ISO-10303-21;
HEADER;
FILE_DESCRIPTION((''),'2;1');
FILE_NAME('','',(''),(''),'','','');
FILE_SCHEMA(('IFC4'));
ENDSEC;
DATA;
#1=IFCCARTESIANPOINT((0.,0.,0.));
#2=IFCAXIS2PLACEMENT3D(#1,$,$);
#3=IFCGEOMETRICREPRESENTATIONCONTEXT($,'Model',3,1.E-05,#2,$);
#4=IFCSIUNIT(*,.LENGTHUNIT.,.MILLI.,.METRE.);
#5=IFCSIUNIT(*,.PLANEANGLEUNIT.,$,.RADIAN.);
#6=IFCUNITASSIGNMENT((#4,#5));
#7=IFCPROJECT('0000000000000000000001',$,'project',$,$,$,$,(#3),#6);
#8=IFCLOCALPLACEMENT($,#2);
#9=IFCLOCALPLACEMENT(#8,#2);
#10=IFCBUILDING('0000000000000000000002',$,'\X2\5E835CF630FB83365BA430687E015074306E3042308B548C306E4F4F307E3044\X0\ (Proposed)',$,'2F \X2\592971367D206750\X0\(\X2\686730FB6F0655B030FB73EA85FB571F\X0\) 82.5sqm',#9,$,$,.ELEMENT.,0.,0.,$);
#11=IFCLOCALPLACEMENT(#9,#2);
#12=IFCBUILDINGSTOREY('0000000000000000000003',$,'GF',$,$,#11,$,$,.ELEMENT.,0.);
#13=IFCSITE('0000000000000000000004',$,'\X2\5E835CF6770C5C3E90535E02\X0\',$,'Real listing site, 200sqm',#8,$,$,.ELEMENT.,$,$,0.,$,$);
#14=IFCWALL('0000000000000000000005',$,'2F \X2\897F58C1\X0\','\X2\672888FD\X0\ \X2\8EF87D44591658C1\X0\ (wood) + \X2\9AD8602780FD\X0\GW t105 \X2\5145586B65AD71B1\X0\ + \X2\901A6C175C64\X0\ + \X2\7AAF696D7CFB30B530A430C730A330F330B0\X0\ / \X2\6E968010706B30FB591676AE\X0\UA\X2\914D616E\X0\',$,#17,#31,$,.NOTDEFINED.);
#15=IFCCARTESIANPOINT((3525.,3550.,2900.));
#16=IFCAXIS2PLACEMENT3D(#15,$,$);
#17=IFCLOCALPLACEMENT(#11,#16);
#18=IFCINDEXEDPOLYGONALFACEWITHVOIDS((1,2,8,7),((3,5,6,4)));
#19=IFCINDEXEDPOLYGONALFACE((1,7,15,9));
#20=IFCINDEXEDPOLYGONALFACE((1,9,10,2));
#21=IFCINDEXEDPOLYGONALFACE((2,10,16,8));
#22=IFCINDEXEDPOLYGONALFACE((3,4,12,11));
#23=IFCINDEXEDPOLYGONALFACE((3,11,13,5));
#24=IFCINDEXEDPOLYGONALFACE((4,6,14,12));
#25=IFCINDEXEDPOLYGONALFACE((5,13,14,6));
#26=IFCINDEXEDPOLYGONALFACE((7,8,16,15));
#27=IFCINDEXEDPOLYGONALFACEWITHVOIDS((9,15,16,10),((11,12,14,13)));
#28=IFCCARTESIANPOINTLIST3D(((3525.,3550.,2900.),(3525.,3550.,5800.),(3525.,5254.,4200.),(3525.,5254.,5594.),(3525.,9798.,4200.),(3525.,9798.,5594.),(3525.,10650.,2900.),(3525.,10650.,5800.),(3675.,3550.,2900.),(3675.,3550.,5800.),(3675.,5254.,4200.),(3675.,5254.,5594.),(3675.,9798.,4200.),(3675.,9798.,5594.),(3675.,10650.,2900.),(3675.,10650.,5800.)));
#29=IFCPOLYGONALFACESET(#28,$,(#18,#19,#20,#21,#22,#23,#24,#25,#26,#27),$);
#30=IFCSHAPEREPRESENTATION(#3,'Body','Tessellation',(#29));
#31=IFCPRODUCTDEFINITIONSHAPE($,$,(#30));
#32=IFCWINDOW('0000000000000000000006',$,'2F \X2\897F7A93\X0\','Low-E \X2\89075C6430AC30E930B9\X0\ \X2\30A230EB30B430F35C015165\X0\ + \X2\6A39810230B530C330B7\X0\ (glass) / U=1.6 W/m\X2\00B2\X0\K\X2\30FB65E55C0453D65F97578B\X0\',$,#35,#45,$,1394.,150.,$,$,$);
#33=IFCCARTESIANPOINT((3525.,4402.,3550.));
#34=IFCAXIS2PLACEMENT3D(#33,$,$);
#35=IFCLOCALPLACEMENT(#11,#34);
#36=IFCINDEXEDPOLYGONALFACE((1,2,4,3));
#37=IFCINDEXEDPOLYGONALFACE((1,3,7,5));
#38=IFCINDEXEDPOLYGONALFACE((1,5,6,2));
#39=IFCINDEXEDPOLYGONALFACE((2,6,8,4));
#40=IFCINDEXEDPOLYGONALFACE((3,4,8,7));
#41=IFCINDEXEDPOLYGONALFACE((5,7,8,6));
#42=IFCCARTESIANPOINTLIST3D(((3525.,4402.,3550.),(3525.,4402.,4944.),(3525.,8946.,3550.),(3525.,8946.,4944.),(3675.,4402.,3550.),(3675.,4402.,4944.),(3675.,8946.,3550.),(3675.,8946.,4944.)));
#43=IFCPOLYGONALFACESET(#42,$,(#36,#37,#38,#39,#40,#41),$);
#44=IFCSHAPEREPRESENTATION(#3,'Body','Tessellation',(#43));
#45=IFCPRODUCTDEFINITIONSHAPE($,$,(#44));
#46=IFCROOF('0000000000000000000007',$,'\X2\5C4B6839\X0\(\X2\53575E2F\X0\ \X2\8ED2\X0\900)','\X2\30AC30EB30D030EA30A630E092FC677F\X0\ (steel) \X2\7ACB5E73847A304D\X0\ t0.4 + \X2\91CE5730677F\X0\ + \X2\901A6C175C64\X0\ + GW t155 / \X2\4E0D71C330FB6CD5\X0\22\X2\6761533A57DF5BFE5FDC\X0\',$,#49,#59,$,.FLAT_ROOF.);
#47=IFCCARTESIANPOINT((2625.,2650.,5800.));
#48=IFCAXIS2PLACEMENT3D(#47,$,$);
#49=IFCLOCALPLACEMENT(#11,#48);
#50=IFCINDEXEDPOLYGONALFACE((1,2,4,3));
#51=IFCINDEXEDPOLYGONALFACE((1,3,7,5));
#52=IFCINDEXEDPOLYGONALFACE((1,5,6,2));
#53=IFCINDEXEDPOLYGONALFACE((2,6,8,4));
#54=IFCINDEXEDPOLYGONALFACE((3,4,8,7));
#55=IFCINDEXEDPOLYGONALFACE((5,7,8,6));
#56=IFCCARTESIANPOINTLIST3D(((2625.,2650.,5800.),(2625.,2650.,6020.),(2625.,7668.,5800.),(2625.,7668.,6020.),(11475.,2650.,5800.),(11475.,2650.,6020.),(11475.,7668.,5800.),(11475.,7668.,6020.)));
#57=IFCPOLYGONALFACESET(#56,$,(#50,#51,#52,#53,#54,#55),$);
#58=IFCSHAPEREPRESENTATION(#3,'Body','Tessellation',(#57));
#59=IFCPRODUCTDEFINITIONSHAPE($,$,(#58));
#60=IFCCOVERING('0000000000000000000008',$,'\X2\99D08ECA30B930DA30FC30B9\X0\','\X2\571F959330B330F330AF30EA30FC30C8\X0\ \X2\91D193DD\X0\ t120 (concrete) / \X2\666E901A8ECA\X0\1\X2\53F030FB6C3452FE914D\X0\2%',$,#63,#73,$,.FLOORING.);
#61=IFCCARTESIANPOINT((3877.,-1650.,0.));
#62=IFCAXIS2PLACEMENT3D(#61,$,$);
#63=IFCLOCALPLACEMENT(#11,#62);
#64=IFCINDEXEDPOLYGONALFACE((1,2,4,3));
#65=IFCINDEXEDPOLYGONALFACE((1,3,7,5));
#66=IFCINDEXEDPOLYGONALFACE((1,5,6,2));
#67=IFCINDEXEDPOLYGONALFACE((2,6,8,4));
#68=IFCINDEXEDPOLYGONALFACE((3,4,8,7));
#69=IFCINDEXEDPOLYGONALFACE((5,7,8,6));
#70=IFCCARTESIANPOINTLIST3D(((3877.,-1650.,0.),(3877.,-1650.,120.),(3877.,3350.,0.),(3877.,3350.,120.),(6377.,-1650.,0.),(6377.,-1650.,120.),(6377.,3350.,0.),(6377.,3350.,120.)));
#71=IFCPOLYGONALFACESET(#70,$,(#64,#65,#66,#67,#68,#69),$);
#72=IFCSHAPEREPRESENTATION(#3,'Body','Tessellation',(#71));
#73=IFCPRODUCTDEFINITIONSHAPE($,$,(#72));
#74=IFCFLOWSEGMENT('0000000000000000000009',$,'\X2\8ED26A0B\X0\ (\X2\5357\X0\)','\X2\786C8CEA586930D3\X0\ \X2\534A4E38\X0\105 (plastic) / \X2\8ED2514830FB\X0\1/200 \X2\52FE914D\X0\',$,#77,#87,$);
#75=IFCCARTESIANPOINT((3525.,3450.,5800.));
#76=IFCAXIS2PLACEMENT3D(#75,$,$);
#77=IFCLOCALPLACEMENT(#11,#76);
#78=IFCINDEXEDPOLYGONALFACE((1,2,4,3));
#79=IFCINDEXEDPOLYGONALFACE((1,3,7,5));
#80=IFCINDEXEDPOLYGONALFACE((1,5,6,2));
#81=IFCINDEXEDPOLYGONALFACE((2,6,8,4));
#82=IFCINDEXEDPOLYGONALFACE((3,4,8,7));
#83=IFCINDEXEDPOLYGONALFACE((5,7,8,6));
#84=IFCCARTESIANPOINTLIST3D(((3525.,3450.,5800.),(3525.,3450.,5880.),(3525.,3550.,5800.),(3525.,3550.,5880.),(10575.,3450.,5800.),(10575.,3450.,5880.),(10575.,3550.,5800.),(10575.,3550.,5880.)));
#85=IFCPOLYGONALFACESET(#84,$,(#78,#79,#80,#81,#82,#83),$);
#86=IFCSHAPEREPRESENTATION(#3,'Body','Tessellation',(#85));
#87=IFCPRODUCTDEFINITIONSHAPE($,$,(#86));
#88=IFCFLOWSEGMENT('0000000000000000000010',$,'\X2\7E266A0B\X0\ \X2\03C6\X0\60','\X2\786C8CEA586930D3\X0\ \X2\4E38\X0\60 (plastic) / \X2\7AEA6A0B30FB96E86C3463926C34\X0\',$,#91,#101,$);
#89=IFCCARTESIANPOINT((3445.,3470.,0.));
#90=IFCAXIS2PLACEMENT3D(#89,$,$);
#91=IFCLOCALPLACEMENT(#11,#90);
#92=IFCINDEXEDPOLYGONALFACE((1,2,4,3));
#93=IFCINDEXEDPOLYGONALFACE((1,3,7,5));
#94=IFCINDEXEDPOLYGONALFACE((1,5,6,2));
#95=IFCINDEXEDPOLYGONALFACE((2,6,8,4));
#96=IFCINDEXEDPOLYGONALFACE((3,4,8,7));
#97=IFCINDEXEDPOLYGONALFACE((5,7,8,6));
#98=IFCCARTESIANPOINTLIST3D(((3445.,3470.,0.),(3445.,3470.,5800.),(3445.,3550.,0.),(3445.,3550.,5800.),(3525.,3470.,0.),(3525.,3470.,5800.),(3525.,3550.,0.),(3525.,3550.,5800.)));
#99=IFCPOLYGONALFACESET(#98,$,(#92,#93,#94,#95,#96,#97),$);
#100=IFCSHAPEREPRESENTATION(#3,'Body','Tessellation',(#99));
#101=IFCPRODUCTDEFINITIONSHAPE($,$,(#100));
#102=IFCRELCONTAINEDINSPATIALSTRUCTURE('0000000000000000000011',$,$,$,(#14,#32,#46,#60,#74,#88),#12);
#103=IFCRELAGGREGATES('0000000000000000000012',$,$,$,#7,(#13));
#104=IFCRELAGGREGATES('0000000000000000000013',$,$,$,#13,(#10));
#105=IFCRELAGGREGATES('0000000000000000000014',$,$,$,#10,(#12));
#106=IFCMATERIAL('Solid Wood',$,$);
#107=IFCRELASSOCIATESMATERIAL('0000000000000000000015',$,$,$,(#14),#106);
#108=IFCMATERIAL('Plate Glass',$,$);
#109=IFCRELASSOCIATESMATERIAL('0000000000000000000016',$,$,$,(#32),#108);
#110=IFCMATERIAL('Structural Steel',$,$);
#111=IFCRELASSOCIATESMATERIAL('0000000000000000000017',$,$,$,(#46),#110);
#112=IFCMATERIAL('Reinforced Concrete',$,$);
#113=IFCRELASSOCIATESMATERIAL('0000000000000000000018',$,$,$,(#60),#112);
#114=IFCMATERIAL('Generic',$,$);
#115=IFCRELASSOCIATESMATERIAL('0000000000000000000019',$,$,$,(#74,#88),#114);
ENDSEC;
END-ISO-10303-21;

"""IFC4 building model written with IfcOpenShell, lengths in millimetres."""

from ifc_helpers import new_model, si_unit, frame, frame_2d, origin, place, context, project, spatial, rectangle, extrude, material, element, fill, save


model = new_model("IFC4")

# Units and contexts
model_context = context("Model", 3, precision=1e-05, world=origin())
ifc_project = project(units=[si_unit("LENGTHUNIT", "METRE", prefix="MILLI"), si_unit("PLANEANGLEUNIT", "RADIAN")], contexts=[model_context])

# Site, building, storey
site_placement = place(None, origin())
site = spatial("IfcSite", under=ifc_project, at=site_placement, Name="広島県尾道市", ObjectType="Real listing site, 200sqm", CompositionType="ELEMENT", RefElevation=0.0)
building_placement = place(site_placement, origin())
building = spatial("IfcBuilding", under=site, at=building_placement, Name="広島・茶室と縁側のある和の住まい (Proposed)", ObjectType="2F 天然素材(桧・漆喰・珪藻土) 82.5sqm", CompositionType="ELEMENT", ElevationOfRefHeight=0.0, ElevationOfTerrain=0.0)
storey_placement = place(building_placement, origin())
storey = spatial("IfcBuildingStorey", under=building, at=storey_placement, Name="GF", CompositionType="ELEMENT", Elevation=0.0)

# Shared definitions
ifc_material_1 = material(Name="Solid Wood")

# Shared definitions
ifc_material_2 = material(Name="Reinforced Concrete")

# Shared definitions
ifc_material_3 = material(Name="Plate Glass")

# Wall, opening, window
wall_1_placement = place(storey_placement, frame((3525.0, 3550.0, 2900.0)))
wall_1 = element("IfcWall", 1, at=wall_1_placement, inside=storey, material=ifc_material_1, Name="2F 西壁", Description="木製 軸組外壁 (wood) + 高性能GW t105 充填断熱 + 通気層 + 窯業系サイディング / 準耐火・外皮UA配慮", PredefinedType="NOTDEFINED", context=model_context, shape_type="SweptSolid", body=[
    extrude(rectangle(XDim=150.0, YDim=7100.0, at=frame_2d((75.0, 3550.0))), frame((3525.0, 3550.0, 2900.0)), (0.0, 0.0, 1.0), 2900.0),
])
opening_1_placement = place(storey_placement, frame((3525.0, 4402.0, 3550.0)))
opening_1 = element("IfcOpeningElement", 2, at=opening_1_placement, cuts=wall_1, PredefinedType="NOTDEFINED", context=model_context, shape_type="SweptSolid", body=[
    extrude(rectangle(XDim=150.0, YDim=4544.0, at=frame_2d((75.0, 2272.0))), frame((3525.0, 4402.0, 3550.0)), (0.0, 0.0, 1.0), 1394.0),
])
window_1_placement = place(storey_placement, frame((3525.0, 4402.0, 3550.0)))
window_1 = element("IfcWindow", 3, at=window_1_placement, inside=storey, material=ifc_material_3, Name="2F 西窓", Description="Low-E 複層ガラス アルゴン封入 + 樹脂サッシ (glass) / U=1.6 W/m²K・日射取得型", OverallHeight=1394.0, OverallWidth=150.0, context=model_context, shape_type="SweptSolid", body=[
    extrude(rectangle(XDim=150.0, YDim=4544.0, at=frame_2d((75.0, 2272.0))), frame((3525.0, 4402.0, 3550.0)), (0.0, 0.0, 1.0), 1394.0),
])
fill(opening_1, window_1)

# Roof
ifc_material_4 = material(Name="Structural Steel")
for number, where, name in (
    (4, (2625.0, 2650.0, 5800.0), "屋根(南帯 軒900)"),
):
    element("IfcRoof", number, at=place(storey_placement, frame(where)), inside=storey, material=ifc_material_4, Name=name, Description="ガルバリウム鋼板 (steel) 立平葺き t0.4 + 野地板 + 通気層 + GW t155 / 不燃・法22条区域対応", PredefinedType="FLAT_ROOF", context=model_context, shape_type="SweptSolid", body=[
        extrude(rectangle(XDim=8850.0, YDim=5018.0, at=frame_2d((4425.0, 2509.0))), frame((2625.0, 2650.0, 5800.0)), (0.0, 0.0, 1.0), 220.0),
    ])

# Covering
covering_placement = place(storey_placement, frame((3877.0, -1650.0, 0.0)))
element("IfcCovering", 5, at=covering_placement, inside=storey, material=ifc_material_2, Name="駐車スペース", Description="土間コンクリート 金鏝 t120 (concrete) / 普通車1台・水勾配2%", PredefinedType="FLOORING", context=model_context, shape_type="SweptSolid", body=[
    extrude(rectangle(XDim=2500.0, YDim=5000.0, at=frame_2d((1250.0, 2500.0))), frame((3877.0, -1650.0, 0.0)), (0.0, 0.0, 1.0), 120.0),
])

# Flow segments
ifc_material_5 = material(Name="Generic")
flow_segment_1_placement = place(storey_placement, frame((3525.0, 3450.0, 5800.0)))
element("IfcFlowSegment", 6, at=flow_segment_1_placement, inside=storey, material=ifc_material_5, Name="軒樋 (南)", Description="硬質塩ビ 半丸105 (plastic) / 軒先・1/200 勾配", context=model_context, shape_type="SweptSolid", body=[
    extrude(rectangle(XDim=7050.0, YDim=100.0, at=frame_2d((3525.0, 50.0))), frame((3525.0, 3450.0, 5800.0)), (0.0, 0.0, 1.0), 80.0),
])
flow_segment_2_placement = place(storey_placement, frame((3445.0, 3470.0, 0.0)))
element("IfcFlowSegment", 7, at=flow_segment_2_placement, inside=storey, material=ifc_material_5, Name="縦樋 φ60", Description="硬質塩ビ 丸60 (plastic) / 竪樋・雨水排水", context=model_context, shape_type="SweptSolid", body=[
    extrude(rectangle(XDim=80.0, YDim=80.0, at=frame_2d((40.0, 40.0))), frame((3445.0, 3470.0, 0.0)), (0.0, 0.0, 1.0), 5800.0),
])

save(model, "model.ifc")
